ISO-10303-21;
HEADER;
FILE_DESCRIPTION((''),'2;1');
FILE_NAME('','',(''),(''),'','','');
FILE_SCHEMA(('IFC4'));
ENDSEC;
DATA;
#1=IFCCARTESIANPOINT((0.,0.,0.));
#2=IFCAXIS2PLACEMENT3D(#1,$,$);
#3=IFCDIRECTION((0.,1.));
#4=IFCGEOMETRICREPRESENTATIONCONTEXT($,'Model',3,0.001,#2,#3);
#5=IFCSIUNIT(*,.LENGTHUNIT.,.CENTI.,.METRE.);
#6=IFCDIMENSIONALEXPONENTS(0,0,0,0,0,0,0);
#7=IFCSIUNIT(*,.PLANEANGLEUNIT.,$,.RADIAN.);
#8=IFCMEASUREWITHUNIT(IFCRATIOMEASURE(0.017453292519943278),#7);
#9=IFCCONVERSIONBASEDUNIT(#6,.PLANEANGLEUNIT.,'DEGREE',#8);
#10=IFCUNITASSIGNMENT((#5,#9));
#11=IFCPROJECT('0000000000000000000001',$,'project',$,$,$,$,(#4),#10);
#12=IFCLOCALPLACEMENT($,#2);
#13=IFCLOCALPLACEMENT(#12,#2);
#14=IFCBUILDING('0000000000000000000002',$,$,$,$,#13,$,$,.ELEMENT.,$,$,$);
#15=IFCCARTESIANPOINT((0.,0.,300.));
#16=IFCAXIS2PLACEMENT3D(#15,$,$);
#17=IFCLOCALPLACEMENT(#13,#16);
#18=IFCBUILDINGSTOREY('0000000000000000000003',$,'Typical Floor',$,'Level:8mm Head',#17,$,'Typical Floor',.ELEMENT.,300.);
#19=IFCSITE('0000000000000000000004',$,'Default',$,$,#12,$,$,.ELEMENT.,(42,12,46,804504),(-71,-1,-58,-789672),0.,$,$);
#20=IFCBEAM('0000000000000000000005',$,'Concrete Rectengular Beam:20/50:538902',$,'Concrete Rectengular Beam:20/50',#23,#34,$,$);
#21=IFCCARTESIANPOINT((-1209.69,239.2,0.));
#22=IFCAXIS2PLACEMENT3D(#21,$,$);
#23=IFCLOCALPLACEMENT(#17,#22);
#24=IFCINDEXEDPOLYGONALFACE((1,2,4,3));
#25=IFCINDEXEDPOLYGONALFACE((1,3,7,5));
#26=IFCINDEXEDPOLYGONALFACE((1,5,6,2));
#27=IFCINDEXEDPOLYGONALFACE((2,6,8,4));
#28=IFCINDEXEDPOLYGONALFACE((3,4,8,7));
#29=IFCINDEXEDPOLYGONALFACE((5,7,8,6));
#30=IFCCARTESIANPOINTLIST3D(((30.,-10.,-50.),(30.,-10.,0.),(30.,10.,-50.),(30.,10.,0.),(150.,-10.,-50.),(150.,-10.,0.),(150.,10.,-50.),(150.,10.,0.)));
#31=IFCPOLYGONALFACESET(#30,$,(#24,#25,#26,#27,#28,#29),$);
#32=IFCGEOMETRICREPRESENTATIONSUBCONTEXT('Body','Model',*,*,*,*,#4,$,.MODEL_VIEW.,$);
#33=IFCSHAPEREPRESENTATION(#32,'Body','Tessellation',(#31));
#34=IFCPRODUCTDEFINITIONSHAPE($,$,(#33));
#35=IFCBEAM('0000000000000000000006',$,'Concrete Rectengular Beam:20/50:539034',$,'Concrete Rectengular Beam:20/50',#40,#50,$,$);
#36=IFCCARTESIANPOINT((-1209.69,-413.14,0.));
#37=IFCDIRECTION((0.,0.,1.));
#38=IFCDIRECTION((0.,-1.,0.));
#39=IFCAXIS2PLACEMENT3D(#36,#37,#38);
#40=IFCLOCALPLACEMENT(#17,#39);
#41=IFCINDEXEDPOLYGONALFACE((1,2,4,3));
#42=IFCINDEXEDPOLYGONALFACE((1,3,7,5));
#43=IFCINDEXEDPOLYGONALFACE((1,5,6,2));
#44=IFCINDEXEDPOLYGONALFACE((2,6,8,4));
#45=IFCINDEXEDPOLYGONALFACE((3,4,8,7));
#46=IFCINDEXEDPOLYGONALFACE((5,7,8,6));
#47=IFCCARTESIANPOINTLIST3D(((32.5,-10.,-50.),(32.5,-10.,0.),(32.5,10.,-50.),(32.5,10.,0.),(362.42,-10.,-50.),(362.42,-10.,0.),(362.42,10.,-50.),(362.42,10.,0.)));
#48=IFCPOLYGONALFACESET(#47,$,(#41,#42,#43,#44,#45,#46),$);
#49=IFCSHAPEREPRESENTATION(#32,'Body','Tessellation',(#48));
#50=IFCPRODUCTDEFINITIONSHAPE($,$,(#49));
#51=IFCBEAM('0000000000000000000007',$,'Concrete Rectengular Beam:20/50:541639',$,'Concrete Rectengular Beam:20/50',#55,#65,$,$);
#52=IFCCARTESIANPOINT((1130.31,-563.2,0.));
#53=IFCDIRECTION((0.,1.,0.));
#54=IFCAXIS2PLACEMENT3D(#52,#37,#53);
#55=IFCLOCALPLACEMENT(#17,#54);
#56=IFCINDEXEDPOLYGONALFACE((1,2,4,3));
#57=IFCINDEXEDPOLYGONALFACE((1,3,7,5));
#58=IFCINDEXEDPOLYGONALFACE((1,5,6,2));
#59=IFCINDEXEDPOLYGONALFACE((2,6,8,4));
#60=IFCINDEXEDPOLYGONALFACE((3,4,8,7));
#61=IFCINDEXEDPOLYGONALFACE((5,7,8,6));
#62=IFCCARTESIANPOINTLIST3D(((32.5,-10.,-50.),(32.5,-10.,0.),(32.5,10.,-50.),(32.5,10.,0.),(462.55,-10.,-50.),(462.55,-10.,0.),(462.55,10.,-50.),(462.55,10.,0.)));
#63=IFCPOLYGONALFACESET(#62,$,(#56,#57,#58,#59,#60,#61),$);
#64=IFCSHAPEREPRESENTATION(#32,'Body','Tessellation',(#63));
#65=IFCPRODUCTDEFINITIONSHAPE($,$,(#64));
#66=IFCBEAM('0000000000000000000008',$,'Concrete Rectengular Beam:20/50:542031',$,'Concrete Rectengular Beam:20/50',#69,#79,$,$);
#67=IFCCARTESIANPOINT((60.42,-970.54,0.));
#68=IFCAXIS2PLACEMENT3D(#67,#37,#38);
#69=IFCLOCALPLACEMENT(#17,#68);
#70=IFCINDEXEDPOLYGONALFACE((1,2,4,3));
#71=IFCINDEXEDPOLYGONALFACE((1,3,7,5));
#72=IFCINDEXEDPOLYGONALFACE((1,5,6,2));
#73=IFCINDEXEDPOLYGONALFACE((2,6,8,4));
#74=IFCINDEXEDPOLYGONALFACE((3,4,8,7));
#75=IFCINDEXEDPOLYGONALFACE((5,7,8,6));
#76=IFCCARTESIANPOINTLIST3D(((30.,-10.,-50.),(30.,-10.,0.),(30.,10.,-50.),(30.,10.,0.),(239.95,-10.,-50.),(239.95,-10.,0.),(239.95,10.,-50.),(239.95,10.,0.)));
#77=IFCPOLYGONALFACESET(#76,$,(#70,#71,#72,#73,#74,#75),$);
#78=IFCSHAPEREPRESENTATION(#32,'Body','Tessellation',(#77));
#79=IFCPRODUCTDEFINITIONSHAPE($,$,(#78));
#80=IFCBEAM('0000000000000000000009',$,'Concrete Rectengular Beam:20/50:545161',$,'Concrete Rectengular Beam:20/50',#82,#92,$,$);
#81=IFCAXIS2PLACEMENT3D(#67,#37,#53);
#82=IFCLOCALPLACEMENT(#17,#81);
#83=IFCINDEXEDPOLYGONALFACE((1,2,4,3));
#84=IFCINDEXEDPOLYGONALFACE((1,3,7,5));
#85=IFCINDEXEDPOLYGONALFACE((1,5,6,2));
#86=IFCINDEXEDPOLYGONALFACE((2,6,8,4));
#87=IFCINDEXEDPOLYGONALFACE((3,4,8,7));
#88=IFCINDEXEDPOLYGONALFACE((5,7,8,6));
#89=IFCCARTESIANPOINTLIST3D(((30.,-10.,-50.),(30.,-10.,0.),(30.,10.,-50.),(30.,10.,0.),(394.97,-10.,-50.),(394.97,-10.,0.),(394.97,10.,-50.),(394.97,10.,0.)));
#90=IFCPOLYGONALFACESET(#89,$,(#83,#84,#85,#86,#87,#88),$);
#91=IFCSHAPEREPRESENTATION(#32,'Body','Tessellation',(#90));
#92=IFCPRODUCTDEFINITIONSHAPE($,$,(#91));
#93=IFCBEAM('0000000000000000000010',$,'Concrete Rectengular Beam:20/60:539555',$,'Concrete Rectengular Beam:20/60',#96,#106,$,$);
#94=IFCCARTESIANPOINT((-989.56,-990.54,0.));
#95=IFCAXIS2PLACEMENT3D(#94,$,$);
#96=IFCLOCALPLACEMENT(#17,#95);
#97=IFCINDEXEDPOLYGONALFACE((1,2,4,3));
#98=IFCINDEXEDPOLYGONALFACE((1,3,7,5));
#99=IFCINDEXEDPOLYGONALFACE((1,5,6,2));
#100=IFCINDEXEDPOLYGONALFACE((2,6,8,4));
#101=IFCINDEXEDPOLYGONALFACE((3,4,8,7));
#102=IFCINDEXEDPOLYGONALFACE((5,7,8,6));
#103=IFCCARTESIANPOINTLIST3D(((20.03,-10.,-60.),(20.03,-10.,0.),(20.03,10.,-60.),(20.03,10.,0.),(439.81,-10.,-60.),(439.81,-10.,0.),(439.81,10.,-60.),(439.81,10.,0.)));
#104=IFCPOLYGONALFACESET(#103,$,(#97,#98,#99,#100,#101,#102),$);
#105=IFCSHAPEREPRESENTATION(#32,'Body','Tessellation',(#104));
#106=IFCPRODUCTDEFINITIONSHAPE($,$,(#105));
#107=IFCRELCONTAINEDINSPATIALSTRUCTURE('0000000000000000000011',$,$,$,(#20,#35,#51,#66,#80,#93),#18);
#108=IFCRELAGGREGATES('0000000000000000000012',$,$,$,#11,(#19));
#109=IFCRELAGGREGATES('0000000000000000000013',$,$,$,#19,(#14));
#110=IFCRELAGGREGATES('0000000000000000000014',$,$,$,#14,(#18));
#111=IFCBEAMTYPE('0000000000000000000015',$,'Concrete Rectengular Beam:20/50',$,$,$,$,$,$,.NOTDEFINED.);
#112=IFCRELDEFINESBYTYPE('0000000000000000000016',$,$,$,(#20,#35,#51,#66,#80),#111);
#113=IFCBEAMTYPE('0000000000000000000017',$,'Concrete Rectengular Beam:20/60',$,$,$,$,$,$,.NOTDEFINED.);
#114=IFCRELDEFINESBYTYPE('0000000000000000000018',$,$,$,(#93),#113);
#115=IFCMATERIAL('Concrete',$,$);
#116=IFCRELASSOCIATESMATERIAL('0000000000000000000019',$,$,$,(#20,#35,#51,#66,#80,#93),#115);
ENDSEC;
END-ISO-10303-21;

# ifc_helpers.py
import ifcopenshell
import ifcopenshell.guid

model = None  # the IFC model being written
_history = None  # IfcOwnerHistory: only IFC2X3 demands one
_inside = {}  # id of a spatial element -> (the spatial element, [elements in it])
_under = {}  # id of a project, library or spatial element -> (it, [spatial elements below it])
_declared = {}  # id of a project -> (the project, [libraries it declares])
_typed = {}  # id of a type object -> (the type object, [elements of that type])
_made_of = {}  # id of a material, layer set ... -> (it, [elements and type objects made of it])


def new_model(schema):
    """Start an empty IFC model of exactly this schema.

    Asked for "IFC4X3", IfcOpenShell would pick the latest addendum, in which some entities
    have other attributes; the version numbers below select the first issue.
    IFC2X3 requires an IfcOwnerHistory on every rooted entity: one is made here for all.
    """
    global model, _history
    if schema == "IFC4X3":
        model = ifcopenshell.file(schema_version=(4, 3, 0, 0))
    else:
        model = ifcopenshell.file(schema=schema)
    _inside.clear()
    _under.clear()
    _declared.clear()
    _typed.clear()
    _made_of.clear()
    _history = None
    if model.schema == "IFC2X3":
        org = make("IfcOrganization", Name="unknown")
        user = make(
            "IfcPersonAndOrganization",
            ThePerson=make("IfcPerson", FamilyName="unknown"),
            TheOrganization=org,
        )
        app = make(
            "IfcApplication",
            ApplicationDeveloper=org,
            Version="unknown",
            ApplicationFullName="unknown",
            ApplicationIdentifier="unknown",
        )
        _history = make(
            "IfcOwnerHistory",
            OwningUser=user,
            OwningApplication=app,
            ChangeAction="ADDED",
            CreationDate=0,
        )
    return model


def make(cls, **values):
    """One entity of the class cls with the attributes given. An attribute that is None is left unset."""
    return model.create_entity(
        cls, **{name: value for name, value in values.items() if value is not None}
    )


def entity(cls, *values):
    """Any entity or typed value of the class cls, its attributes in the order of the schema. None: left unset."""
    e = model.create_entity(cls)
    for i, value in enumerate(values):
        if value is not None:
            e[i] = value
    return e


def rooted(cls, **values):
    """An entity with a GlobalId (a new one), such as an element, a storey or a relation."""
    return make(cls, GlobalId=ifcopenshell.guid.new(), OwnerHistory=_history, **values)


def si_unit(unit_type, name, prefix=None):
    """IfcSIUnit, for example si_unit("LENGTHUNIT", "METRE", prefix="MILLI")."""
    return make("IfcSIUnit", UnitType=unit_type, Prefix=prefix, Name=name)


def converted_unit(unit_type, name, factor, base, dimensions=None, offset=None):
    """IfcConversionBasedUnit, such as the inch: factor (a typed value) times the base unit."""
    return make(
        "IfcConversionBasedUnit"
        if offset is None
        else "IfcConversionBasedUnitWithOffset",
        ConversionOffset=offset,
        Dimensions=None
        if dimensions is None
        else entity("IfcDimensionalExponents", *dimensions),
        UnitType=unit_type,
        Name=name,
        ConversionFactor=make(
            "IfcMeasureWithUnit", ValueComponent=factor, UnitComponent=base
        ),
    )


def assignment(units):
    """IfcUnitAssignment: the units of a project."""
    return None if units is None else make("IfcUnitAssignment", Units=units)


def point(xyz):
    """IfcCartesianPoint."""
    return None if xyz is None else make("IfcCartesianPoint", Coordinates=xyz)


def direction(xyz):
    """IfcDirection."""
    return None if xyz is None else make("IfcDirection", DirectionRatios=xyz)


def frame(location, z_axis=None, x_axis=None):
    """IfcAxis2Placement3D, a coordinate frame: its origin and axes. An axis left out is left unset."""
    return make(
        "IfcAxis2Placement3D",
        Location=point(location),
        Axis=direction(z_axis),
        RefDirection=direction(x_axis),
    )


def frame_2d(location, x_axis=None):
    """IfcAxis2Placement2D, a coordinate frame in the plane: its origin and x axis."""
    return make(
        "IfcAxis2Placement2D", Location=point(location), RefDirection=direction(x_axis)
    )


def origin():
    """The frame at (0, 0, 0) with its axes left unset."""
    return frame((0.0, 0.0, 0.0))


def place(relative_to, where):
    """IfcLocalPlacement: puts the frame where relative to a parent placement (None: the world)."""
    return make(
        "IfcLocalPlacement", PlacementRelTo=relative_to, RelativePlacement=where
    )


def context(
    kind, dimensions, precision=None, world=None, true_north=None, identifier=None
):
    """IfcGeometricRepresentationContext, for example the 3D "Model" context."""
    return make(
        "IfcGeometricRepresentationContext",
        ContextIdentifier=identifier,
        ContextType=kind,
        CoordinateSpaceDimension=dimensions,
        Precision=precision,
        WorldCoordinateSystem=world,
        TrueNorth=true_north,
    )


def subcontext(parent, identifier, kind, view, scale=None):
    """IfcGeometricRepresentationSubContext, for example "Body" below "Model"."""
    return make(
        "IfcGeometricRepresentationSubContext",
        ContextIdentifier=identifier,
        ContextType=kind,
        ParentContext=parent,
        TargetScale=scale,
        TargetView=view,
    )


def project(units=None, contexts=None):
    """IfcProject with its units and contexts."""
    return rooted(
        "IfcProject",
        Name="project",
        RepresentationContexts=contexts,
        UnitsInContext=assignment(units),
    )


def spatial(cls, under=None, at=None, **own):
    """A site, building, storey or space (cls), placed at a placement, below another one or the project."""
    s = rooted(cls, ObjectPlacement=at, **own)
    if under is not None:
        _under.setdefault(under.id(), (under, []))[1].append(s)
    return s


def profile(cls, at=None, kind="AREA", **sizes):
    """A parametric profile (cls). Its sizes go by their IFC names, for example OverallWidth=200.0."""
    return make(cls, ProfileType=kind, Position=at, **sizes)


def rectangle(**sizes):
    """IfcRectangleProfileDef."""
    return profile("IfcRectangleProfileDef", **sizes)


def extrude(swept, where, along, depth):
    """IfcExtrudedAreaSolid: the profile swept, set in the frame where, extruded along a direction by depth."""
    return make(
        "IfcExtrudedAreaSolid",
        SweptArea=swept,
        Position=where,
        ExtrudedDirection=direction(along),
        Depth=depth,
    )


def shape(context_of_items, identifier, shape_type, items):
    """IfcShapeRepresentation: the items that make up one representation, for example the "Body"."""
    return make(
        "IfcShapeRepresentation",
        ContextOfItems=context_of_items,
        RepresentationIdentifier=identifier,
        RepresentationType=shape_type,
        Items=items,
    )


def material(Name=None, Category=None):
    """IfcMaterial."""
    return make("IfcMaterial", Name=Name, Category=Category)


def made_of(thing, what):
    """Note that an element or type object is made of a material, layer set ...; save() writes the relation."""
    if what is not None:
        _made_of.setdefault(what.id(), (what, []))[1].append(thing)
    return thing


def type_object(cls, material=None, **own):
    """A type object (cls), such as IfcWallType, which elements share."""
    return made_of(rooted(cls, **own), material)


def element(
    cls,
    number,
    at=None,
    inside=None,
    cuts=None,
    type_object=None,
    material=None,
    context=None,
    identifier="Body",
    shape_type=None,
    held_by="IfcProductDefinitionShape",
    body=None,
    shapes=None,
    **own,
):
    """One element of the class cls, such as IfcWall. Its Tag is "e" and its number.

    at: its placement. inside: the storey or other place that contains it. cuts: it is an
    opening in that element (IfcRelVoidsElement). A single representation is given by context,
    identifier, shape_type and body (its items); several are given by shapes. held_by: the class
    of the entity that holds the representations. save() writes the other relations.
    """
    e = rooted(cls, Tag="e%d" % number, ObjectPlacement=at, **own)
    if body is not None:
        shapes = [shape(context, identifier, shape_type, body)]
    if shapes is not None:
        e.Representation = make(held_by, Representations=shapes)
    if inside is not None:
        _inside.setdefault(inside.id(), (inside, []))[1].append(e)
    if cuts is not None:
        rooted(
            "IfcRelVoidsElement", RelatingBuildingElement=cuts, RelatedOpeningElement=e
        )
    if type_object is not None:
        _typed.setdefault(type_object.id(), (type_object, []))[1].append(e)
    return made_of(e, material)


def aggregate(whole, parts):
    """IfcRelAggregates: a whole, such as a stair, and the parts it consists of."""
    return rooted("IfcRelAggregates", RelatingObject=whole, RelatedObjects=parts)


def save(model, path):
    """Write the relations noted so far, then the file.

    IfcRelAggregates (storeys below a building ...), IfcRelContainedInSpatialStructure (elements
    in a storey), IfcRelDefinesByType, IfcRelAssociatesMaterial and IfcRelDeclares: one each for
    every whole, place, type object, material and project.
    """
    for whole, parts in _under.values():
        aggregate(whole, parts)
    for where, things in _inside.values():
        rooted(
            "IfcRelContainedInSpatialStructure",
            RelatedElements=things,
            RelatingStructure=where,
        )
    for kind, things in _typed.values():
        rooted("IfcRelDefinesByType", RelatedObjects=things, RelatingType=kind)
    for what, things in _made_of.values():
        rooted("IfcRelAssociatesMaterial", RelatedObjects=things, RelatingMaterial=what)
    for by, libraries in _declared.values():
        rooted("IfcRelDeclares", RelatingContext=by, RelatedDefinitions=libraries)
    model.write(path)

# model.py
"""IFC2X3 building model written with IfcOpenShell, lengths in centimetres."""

from ifc_helpers import new_model, entity, si_unit, converted_unit, direction, frame, frame_2d, origin, place, context, subcontext, project, spatial, rectangle, extrude, material, type_object, element, save


model = new_model("IFC2X3")

# Units and contexts
model_context = context("Model", 3, precision=0.001, world=origin(), true_north=direction((0.0, 1.0)))
body_context = subcontext(model_context, "Body", "Model", "MODEL_VIEW")
ifc_project = project(units=[si_unit("LENGTHUNIT", "METRE", prefix="CENTI"), converted_unit("PLANEANGLEUNIT", "DEGREE", entity("IfcRatioMeasure", 0.017453292519943278), si_unit("PLANEANGLEUNIT", "RADIAN"), dimensions=[0, 0, 0, 0, 0, 0, 0])], contexts=[model_context])

# Site, building, storey
site_placement = place(None, origin())
site = spatial("IfcSite", under=ifc_project, at=site_placement, Name="Default", CompositionType="ELEMENT", RefLatitude=(42, 12, 46, 804504), RefLongitude=(-71, -1, -58, -789672), RefElevation=0.0)
building_placement = place(site_placement, origin())
building = spatial("IfcBuilding", under=site, at=building_placement, CompositionType="ELEMENT")
storey_placement = place(building_placement, frame((0.0, 0.0, 300.0)))
storey = spatial("IfcBuildingStorey", under=building, at=storey_placement, Name="Typical Floor", ObjectType="Level:8mm Head", LongName="Typical Floor", CompositionType="ELEMENT", Elevation=300.0)

# Beams
ifc_material = material(Name="Concrete")
beam_type_1 = type_object("IfcBeamType", Name="Concrete Rectengular Beam:20/50", PredefinedType="NOTDEFINED")
beam_1_placement = place(storey_placement, frame((-1209.69, 239.2, 0.0)))
element("IfcBeam", 1, at=beam_1_placement, inside=storey, type_object=beam_type_1, material=ifc_material, Name="Concrete Rectengular Beam:20/50:538902", ObjectType="Concrete Rectengular Beam:20/50", context=body_context, shape_type="SweptSolid", body=[
    extrude(rectangle(XDim=50.0, YDim=20.0, at=frame_2d((0.0, 0.0), x_axis=(1.0, 0.0))), frame((30.0, 0.0, -25.0), z_axis=(1.0, 0.0, 0.0), x_axis=(0.0, 0.0, -1.0)), (0.0, 0.0, 1.0), 120.0),
])
beam_2_placement = place(storey_placement, frame((-1209.69, -413.14, 0.0), z_axis=(0.0, 0.0, 1.0), x_axis=(0.0, -1.0, 0.0)))
element("IfcBeam", 2, at=beam_2_placement, inside=storey, type_object=beam_type_1, material=ifc_material, Name="Concrete Rectengular Beam:20/50:539034", ObjectType="Concrete Rectengular Beam:20/50", context=body_context, shape_type="SweptSolid", body=[
    extrude(rectangle(XDim=50.0, YDim=20.0, at=frame_2d((0.0, 0.0), x_axis=(1.0, 0.0))), frame((32.5, 0.0, -25.0), z_axis=(1.0, 0.0, 0.0), x_axis=(0.0, 0.0, -1.0)), (0.0, 0.0, 1.0), 329.92),
])
beam_3_placement = place(storey_placement, frame((1130.31, -563.2, 0.0), z_axis=(0.0, 0.0, 1.0), x_axis=(0.0, 1.0, 0.0)))
element("IfcBeam", 3, at=beam_3_placement, inside=storey, type_object=beam_type_1, material=ifc_material, Name="Concrete Rectengular Beam:20/50:541639", ObjectType="Concrete Rectengular Beam:20/50", context=body_context, shape_type="SweptSolid", body=[
    extrude(rectangle(XDim=50.0, YDim=20.0, at=frame_2d((0.0, 0.0), x_axis=(1.0, 0.0))), frame((32.5, 0.0, -25.0), z_axis=(1.0, 0.0, 0.0), x_axis=(0.0, 0.0, -1.0)), (0.0, 0.0, 1.0), 430.05),
])
beam_4_placement = place(storey_placement, frame((60.42, -970.54, 0.0), z_axis=(0.0, 0.0, 1.0), x_axis=(0.0, -1.0, 0.0)))
element("IfcBeam", 4, at=beam_4_placement, inside=storey, type_object=beam_type_1, material=ifc_material, Name="Concrete Rectengular Beam:20/50:542031", ObjectType="Concrete Rectengular Beam:20/50", context=body_context, shape_type="SweptSolid", body=[
    extrude(rectangle(XDim=50.0, YDim=20.0, at=frame_2d((0.0, 0.0), x_axis=(1.0, 0.0))), frame((30.0, 0.0, -25.0), z_axis=(1.0, 0.0, 0.0), x_axis=(0.0, 0.0, -1.0)), (0.0, 0.0, 1.0), 209.95),
])
beam_5_placement = place(storey_placement, frame((60.42, -970.54, 0.0), z_axis=(0.0, 0.0, 1.0), x_axis=(0.0, 1.0, 0.0)))
element("IfcBeam", 5, at=beam_5_placement, inside=storey, type_object=beam_type_1, material=ifc_material, Name="Concrete Rectengular Beam:20/50:545161", ObjectType="Concrete Rectengular Beam:20/50", context=body_context, shape_type="SweptSolid", body=[
    extrude(rectangle(XDim=50.0, YDim=20.0, at=frame_2d((0.0, 0.0), x_axis=(1.0, 0.0))), frame((30.0, 0.0, -25.0), z_axis=(1.0, 0.0, 0.0), x_axis=(0.0, 0.0, -1.0)), (0.0, 0.0, 1.0), 364.97),
])
beam_type_2 = type_object("IfcBeamType", Name="Concrete Rectengular Beam:20/60", PredefinedType="NOTDEFINED")
beam_6_placement = place(storey_placement, frame((-989.56, -990.54, 0.0)))
element("IfcBeam", 6, at=beam_6_placement, inside=storey, type_object=beam_type_2, material=ifc_material, Name="Concrete Rectengular Beam:20/60:539555", ObjectType="Concrete Rectengular Beam:20/60", context=body_context, shape_type="SweptSolid", body=[
    extrude(rectangle(XDim=60.0, YDim=20.0, at=frame_2d((0.0, 0.0), x_axis=(1.0, 0.0))), frame((20.03, 0.0, -30.0), z_axis=(1.0, 0.0, 0.0), x_axis=(0.0, 0.0, -1.0)), (0.0, 0.0, 1.0), 419.79),
])

save(model, "model.ifc")
